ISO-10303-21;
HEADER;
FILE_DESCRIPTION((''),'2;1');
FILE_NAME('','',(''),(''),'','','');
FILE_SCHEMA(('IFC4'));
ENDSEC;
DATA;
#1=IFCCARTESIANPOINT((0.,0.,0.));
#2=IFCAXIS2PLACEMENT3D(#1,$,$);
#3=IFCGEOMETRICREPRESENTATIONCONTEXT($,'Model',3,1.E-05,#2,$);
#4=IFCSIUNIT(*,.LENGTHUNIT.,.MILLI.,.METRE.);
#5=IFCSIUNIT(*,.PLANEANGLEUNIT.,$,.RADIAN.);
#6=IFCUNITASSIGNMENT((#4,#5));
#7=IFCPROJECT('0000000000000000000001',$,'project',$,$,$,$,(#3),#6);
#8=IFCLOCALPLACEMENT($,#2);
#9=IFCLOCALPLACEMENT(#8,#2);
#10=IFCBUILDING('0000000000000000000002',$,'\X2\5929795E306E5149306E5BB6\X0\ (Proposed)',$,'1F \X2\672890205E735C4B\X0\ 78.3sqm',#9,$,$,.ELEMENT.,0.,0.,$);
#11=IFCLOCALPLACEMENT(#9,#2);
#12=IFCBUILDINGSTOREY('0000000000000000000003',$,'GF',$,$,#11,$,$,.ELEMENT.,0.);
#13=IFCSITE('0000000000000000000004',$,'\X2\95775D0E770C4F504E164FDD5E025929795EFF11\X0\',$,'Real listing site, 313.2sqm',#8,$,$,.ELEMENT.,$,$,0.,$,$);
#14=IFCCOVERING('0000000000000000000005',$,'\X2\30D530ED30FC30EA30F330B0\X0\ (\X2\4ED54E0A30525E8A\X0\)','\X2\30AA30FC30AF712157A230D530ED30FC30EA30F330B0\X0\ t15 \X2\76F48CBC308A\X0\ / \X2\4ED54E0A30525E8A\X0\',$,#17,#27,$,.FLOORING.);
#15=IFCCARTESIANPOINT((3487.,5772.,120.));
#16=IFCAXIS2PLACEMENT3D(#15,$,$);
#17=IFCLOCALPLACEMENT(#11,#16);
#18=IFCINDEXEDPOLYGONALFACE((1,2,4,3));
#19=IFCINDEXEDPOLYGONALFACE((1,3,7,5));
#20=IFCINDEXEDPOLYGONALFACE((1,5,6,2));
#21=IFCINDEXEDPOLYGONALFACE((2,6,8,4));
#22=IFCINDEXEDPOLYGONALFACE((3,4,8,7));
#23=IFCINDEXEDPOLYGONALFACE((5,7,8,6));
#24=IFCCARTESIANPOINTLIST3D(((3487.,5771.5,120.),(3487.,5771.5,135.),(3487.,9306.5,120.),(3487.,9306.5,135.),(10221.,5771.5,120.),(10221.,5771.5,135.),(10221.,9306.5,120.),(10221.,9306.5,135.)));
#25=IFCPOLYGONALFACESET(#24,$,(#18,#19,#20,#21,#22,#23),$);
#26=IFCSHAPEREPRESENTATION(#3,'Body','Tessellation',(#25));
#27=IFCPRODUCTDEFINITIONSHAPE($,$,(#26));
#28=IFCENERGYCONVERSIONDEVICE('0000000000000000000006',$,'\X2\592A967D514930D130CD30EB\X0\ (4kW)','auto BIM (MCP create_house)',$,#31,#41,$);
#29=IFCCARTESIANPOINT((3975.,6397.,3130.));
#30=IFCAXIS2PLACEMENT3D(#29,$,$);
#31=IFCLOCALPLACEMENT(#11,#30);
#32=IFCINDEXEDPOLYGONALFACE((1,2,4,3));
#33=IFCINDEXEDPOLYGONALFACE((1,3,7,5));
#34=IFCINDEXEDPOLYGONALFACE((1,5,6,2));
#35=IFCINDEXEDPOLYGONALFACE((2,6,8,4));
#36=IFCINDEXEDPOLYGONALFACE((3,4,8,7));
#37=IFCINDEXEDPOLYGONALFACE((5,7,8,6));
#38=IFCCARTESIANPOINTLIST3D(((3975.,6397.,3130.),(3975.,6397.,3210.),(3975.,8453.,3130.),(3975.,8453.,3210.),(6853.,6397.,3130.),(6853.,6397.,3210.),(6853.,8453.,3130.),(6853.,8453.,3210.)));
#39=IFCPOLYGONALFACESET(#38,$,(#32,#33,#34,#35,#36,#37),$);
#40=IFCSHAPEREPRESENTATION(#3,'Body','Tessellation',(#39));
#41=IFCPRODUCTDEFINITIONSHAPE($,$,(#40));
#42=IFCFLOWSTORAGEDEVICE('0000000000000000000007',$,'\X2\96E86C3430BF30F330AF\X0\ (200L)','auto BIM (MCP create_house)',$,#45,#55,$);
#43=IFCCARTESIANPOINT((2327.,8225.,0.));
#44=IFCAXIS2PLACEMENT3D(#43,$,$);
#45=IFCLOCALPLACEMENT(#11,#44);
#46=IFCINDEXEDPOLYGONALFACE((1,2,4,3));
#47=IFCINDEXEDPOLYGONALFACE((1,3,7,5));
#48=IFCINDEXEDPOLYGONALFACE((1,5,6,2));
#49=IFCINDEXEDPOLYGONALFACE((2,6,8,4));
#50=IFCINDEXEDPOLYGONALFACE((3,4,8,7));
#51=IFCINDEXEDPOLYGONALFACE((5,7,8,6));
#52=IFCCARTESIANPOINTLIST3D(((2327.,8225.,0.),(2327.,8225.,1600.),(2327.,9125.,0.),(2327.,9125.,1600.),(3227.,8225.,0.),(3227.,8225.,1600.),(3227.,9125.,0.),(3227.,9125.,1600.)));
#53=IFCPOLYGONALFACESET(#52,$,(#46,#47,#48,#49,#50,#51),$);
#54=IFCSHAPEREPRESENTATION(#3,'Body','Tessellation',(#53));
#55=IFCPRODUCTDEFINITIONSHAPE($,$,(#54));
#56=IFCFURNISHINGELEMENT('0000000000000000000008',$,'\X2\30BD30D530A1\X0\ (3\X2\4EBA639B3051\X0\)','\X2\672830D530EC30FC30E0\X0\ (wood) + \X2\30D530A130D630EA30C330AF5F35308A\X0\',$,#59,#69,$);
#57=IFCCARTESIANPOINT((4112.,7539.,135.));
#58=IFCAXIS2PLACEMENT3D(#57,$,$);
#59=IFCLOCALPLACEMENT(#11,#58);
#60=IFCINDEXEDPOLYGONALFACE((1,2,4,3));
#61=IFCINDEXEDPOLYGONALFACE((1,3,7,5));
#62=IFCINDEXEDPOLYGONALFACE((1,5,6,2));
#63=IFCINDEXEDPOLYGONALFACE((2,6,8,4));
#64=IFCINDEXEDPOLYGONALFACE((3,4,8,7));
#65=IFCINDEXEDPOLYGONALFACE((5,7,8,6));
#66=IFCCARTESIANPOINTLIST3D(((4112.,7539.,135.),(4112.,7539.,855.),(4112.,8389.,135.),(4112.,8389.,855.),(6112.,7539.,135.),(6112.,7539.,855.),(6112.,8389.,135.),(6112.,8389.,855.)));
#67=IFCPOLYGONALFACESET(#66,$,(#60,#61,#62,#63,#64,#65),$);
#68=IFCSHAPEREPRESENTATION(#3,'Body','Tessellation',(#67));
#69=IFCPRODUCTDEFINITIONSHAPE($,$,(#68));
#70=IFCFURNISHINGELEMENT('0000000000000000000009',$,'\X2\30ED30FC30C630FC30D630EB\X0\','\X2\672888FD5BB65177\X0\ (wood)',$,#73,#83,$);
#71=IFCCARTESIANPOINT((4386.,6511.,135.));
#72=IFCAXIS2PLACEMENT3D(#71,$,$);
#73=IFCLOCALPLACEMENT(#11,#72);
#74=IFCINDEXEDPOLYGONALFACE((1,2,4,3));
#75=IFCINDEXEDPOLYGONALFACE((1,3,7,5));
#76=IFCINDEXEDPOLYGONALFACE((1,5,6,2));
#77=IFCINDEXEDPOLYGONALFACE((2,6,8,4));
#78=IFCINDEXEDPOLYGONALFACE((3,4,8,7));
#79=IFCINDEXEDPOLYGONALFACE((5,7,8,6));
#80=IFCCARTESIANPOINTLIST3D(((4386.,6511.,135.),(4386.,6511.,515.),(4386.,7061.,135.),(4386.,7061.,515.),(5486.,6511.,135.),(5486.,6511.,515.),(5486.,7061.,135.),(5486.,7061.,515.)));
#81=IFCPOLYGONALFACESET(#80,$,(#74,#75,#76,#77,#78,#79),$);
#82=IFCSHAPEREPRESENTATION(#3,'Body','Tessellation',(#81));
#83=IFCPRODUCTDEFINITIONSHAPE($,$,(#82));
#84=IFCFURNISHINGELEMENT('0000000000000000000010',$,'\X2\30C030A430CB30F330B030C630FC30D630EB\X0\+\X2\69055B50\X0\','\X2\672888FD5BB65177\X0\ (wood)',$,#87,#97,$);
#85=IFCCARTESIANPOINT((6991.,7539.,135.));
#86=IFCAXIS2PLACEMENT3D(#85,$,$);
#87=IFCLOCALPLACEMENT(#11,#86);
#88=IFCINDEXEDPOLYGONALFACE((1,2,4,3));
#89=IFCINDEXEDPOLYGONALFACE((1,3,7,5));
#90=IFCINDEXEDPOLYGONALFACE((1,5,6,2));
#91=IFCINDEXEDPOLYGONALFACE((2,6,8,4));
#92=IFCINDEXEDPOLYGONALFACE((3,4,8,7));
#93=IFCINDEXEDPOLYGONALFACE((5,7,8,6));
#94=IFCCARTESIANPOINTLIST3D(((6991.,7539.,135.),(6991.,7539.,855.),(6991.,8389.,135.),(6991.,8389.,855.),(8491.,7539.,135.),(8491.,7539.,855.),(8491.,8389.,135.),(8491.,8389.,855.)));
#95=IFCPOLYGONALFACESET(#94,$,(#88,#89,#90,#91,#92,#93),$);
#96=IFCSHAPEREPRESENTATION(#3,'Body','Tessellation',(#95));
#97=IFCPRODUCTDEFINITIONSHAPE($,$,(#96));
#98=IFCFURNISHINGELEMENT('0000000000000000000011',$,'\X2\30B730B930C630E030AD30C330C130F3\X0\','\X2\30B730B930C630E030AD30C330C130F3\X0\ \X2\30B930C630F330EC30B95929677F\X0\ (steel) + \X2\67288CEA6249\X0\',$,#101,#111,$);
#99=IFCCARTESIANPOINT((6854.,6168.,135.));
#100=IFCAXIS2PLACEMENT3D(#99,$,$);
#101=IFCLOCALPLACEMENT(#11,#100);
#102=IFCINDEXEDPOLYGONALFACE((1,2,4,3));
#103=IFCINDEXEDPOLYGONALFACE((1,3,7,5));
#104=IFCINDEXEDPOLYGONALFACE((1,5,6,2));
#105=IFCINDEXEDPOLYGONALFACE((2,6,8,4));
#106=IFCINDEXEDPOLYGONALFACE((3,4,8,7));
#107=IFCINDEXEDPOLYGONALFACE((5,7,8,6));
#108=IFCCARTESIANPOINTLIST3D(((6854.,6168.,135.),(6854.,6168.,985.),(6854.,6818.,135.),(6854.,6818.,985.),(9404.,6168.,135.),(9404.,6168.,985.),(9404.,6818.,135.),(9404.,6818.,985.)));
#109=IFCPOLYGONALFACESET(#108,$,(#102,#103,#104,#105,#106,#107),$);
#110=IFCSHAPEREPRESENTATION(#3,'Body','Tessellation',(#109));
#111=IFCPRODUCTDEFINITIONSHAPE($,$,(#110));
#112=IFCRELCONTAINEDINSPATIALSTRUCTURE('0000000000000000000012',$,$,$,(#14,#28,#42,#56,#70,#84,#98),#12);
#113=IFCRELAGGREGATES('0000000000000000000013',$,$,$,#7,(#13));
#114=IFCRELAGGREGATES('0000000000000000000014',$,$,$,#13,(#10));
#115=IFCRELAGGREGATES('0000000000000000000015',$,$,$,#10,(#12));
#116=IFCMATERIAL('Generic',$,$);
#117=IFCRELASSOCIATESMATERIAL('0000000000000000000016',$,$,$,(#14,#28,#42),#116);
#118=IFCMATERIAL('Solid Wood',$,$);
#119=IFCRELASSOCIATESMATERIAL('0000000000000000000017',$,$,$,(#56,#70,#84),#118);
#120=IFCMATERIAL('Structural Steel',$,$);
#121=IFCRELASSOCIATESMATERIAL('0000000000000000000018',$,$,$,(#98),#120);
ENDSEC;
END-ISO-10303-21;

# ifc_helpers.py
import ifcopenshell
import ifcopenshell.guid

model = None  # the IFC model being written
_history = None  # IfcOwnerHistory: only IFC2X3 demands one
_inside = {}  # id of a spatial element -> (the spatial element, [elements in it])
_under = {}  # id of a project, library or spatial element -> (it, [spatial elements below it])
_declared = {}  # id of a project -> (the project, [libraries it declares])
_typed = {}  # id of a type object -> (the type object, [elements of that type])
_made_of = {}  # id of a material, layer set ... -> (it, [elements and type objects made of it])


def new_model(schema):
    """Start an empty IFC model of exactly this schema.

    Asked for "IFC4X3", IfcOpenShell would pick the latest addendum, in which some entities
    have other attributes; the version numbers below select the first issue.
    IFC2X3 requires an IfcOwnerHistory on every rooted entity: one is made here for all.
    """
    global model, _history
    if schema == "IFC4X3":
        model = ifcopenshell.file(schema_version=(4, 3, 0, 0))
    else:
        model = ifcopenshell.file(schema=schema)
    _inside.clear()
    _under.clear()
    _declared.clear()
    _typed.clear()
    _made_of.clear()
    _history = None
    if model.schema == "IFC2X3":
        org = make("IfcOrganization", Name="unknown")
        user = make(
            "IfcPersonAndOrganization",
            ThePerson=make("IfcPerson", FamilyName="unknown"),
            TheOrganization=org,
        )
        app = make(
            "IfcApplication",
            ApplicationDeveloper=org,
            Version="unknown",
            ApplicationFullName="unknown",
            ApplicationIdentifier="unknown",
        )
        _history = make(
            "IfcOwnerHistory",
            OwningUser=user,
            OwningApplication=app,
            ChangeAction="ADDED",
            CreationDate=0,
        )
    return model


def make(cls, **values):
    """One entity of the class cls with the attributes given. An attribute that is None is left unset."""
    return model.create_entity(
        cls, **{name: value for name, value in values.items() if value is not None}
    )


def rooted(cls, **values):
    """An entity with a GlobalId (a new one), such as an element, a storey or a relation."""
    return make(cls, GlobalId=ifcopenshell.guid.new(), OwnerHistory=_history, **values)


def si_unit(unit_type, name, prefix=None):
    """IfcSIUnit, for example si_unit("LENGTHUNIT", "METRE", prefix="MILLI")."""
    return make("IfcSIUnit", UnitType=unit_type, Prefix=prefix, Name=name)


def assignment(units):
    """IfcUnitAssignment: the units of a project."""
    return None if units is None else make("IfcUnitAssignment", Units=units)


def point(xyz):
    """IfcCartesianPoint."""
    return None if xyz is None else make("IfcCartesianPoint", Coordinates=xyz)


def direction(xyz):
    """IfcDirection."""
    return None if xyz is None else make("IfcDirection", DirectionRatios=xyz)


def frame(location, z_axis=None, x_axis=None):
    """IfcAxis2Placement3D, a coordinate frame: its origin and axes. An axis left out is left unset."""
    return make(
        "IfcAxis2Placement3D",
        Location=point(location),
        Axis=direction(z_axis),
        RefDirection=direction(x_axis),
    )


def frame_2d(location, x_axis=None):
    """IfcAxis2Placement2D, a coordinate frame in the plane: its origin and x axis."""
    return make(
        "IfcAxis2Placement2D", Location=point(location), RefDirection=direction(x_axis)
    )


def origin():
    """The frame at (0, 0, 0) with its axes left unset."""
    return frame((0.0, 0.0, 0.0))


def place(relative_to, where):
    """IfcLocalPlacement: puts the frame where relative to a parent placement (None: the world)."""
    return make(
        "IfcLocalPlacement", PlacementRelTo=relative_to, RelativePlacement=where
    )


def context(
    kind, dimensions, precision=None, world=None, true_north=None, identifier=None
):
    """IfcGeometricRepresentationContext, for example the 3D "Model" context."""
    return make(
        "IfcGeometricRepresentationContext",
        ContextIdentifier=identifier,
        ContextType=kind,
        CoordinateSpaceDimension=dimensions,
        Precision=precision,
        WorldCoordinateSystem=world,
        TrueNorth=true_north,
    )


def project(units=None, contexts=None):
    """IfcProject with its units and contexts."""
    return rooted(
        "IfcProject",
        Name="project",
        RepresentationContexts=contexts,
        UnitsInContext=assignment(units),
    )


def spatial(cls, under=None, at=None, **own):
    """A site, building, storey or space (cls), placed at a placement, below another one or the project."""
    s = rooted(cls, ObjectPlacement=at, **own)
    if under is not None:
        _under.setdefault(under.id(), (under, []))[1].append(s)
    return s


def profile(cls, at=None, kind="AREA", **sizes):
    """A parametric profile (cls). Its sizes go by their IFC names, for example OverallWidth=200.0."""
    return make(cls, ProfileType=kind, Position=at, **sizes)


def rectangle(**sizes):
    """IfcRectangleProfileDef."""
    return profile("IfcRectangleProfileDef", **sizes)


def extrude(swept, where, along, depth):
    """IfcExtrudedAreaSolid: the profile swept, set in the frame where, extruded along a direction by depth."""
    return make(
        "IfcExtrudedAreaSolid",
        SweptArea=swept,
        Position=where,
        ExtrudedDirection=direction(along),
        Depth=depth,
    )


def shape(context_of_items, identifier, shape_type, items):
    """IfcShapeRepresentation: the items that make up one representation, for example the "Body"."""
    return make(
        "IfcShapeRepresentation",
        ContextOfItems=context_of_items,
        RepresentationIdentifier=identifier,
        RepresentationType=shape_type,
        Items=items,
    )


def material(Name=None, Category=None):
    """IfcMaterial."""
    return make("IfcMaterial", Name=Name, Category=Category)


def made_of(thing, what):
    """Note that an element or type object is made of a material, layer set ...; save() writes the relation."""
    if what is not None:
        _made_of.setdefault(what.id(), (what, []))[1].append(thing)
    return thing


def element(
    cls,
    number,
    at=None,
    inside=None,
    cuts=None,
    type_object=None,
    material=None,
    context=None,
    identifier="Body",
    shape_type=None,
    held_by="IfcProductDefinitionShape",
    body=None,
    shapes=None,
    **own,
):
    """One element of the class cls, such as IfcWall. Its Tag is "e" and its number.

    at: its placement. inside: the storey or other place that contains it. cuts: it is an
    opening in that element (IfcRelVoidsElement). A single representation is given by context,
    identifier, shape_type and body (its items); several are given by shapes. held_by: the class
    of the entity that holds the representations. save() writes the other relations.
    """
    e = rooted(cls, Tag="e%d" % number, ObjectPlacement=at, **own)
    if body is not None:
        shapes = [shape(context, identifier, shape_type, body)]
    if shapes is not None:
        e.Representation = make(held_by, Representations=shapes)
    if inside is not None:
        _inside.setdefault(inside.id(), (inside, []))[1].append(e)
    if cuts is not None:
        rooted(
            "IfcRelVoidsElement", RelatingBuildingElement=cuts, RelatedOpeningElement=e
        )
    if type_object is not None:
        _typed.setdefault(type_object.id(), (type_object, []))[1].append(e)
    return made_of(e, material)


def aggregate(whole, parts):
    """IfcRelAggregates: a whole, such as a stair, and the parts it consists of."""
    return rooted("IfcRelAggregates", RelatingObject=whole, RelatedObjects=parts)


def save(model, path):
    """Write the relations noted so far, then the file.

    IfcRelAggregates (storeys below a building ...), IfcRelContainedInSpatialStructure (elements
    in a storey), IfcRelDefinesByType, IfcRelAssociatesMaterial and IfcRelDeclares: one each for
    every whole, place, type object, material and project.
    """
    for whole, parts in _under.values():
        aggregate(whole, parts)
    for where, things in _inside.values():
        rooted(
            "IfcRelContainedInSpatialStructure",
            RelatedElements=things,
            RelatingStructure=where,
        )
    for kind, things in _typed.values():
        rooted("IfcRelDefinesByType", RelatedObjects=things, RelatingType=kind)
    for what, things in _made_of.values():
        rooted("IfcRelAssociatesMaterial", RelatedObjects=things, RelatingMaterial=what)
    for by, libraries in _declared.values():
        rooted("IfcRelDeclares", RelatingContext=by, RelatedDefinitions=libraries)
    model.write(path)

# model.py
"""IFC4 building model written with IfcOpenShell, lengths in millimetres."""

from ifc_helpers import new_model, si_unit, frame, frame_2d, origin, place, context, project, spatial, rectangle, extrude, material, element, save


model = new_model("IFC4")

# Units and contexts
model_context = context("Model", 3, precision=1e-05, world=origin())
ifc_project = project(units=[si_unit("LENGTHUNIT", "METRE", prefix="MILLI"), si_unit("PLANEANGLEUNIT", "RADIAN")], contexts=[model_context])

# Site, building, storey
site_placement = place(None, origin())
site = spatial("IfcSite", under=ifc_project, at=site_placement, Name="長崎県佐世保市天神１", ObjectType="Real listing site, 313.2sqm", CompositionType="ELEMENT", RefElevation=0.0)
building_placement = place(site_placement, origin())
building = spatial("IfcBuilding", under=site, at=building_placement, Name="天神の光の家 (Proposed)", ObjectType="1F 木造平屋 78.3sqm", CompositionType="ELEMENT", ElevationOfRefHeight=0.0, ElevationOfTerrain=0.0)
storey_placement = place(building_placement, origin())
storey = spatial("IfcBuildingStorey", under=building, at=storey_placement, Name="GF", CompositionType="ELEMENT", Elevation=0.0)

# Shared definitions
ifc_material_1 = material(Name="Solid Wood")

# Shared definitions
ifc_material_2 = material(Name="Structural Steel")

# Covering
ifc_material_3 = material(Name="Generic")
covering_placement = place(storey_placement, frame((3487.0, 5772.0, 120.0)))
element("IfcCovering", 1, at=covering_placement, inside=storey, material=ifc_material_3, Name="フローリング (仕上げ床)", Description="オーク無垢フローリング t15 直貼り / 仕上げ床", PredefinedType="FLOORING", context=model_context, shape_type="SweptSolid", body=[
    extrude(rectangle(XDim=6734.0, YDim=3535.0, at=frame_2d((3367.0, 1767.0))), frame((3487.0, 5772.0, 120.0)), (0.0, 0.0, 1.0), 15.0),
])

# Energy conversion device
energy_conversion_device_placement = place(storey_placement, frame((3975.0, 6397.0, 3130.0)))
element("IfcEnergyConversionDevice", 2, at=energy_conversion_device_placement, inside=storey, material=ifc_material_3, Name="太陽光パネル (4kW)", Description="auto BIM (MCP create_house)", context=model_context, shape_type="SweptSolid", body=[
    extrude(rectangle(XDim=2878.0, YDim=2056.0, at=frame_2d((1439.0, 1028.0))), frame((3975.0, 6397.0, 3130.0)), (0.0, 0.0, 1.0), 80.0),
])

# Flow storage device
flow_storage_device_placement = place(storey_placement, frame((2327.0, 8225.0, 0.0)))
element("IfcFlowStorageDevice", 3, at=flow_storage_device_placement, inside=storey, material=ifc_material_3, Name="雨水タンク (200L)", Description="auto BIM (MCP create_house)", context=model_context, shape_type="SweptSolid", body=[
    extrude(rectangle(XDim=900.0, YDim=900.0, at=frame_2d((450.0, 450.0))), frame((2327.0, 8225.0, 0.0)), (0.0, 0.0, 1.0), 1600.0),
])

# Furnishing elements
furnishing_1_placement = place(storey_placement, frame((4112.0, 7539.0, 135.0)))
element("IfcFurnishingElement", 4, at=furnishing_1_placement, inside=storey, material=ifc_material_1, Name="ソファ (3人掛け)", Description="木フレーム (wood) + ファブリック張り", context=model_context, shape_type="SweptSolid", body=[
    extrude(rectangle(XDim=2000.0, YDim=850.0, at=frame_2d((1000.0, 425.0))), frame((4112.0, 7539.0, 135.0)), (0.0, 0.0, 1.0), 720.0),
])
furnishing_2_placement = place(storey_placement, frame((4386.0, 6511.0, 135.0)))
element("IfcFurnishingElement", 5, at=furnishing_2_placement, inside=storey, material=ifc_material_1, Name="ローテーブル", Description="木製家具 (wood)", context=model_context, shape_type="SweptSolid", body=[
    extrude(rectangle(XDim=1100.0, YDim=550.0, at=frame_2d((550.0, 275.0))), frame((4386.0, 6511.0, 135.0)), (0.0, 0.0, 1.0), 380.0),
])
furnishing_3_placement = place(storey_placement, frame((6991.0, 7539.0, 135.0)))
element("IfcFurnishingElement", 6, at=furnishing_3_placement, inside=storey, material=ifc_material_1, Name="ダイニングテーブル+椅子", Description="木製家具 (wood)", context=model_context, shape_type="SweptSolid", body=[
    extrude(rectangle(XDim=1500.0, YDim=850.0, at=frame_2d((750.0, 425.0))), frame((6991.0, 7539.0, 135.0)), (0.0, 0.0, 1.0), 720.0),
])
furnishing_4_placement = place(storey_placement, frame((6854.0, 6168.0, 135.0)))
element("IfcFurnishingElement", 7, at=furnishing_4_placement, inside=storey, material=ifc_material_2, Name="システムキッチン", Description="システムキッチン ステンレス天板 (steel) + 木質扉", context=model_context, shape_type="SweptSolid", body=[
    extrude(rectangle(XDim=2550.0, YDim=650.0, at=frame_2d((1275.0, 325.0))), frame((6854.0, 6168.0, 135.0)), (0.0, 0.0, 1.0), 850.0),
])

save(model, "model.ifc")
